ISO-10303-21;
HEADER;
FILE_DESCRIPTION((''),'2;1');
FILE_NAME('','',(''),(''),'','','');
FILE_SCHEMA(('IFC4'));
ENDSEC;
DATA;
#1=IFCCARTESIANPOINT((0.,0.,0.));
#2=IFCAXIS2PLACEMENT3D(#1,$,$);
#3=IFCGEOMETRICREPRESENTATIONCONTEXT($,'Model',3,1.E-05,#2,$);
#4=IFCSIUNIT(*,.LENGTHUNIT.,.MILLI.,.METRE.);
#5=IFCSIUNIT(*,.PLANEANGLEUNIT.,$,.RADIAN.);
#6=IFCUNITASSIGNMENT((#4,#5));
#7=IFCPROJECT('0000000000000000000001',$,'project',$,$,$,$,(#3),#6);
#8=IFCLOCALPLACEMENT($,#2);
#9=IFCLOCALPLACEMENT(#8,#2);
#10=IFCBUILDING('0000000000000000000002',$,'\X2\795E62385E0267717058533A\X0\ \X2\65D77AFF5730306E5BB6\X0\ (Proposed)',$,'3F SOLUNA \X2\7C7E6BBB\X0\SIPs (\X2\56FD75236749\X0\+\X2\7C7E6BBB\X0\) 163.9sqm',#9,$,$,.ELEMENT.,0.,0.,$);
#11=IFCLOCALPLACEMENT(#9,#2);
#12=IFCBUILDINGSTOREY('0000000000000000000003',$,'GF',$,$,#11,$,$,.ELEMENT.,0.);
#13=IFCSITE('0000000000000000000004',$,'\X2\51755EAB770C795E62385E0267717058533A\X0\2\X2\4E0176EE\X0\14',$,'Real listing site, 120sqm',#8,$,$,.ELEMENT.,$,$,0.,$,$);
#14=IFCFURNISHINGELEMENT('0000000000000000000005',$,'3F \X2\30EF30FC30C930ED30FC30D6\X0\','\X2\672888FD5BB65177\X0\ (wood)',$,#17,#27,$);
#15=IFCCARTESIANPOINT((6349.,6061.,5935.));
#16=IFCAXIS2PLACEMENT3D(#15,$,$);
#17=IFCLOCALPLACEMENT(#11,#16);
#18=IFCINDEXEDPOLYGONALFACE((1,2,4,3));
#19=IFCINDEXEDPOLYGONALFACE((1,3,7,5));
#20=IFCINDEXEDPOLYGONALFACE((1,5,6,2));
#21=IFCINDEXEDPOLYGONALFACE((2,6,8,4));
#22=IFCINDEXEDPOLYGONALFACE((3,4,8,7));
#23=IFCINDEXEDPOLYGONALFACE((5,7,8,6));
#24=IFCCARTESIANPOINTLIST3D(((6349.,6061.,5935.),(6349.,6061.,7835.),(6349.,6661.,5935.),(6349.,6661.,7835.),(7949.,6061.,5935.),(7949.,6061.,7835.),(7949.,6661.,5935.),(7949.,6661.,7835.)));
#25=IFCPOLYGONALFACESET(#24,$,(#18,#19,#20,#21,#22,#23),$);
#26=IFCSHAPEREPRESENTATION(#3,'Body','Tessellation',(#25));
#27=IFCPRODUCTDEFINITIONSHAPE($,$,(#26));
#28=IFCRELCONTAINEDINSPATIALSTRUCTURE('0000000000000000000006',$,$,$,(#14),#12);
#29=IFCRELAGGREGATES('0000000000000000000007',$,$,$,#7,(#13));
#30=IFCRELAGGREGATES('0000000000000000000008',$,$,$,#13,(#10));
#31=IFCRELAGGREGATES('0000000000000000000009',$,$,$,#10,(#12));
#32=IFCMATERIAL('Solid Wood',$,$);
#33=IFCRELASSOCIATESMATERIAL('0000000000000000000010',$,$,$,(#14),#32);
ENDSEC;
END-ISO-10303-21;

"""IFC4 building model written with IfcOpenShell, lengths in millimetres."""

from ifc_helpers import new_model, si_unit, frame, frame_2d, origin, place, context, project, spatial, rectangle, extrude, material, element, save


model = new_model("IFC4")

# Units and contexts
model_context = context("Model", 3, precision=1e-05, world=origin())
ifc_project = project(units=[si_unit("LENGTHUNIT", "METRE", prefix="MILLI"), si_unit("PLANEANGLEUNIT", "RADIAN")], contexts=[model_context])

# Site, building, storey
site_placement = place(None, origin())
site = spatial("IfcSite", under=ifc_project, at=site_placement, Name="兵庫県神戸市東灘区2丁目14", ObjectType="Real listing site, 120sqm", CompositionType="ELEMENT", RefElevation=0.0)
building_placement = place(site_placement, origin())
building = spatial("IfcBuilding", under=site, at=building_placement, Name="神戸市東灘区 旗竿地の家 (Proposed)", ObjectType="3F SOLUNA 籾殻SIPs (国産杉+籾殻) 163.9sqm", CompositionType="ELEMENT", ElevationOfRefHeight=0.0, ElevationOfTerrain=0.0)
storey_placement = place(building_placement, origin())
storey = spatial("IfcBuildingStorey", under=building, at=storey_placement, Name="GF", CompositionType="ELEMENT", Elevation=0.0)

# Shared definitions
ifc_material_1 = material(Name="Solid Wood")

# Furnishing element
furnishing_1_placement = place(storey_placement, frame((6349.0, 6061.0, 5935.0)))
element("IfcFurnishingElement", 1, at=furnishing_1_placement, inside=storey, material=ifc_material_1, Name="3F ワードローブ", Description="木製家具 (wood)", context=model_context, shape_type="SweptSolid", body=[
    extrude(rectangle(XDim=1600.0, YDim=600.0, at=frame_2d((800.0, 300.0))), frame((6349.0, 6061.0, 5935.0)), (0.0, 0.0, 1.0), 1900.0),
])

save(model, "model.ifc")
